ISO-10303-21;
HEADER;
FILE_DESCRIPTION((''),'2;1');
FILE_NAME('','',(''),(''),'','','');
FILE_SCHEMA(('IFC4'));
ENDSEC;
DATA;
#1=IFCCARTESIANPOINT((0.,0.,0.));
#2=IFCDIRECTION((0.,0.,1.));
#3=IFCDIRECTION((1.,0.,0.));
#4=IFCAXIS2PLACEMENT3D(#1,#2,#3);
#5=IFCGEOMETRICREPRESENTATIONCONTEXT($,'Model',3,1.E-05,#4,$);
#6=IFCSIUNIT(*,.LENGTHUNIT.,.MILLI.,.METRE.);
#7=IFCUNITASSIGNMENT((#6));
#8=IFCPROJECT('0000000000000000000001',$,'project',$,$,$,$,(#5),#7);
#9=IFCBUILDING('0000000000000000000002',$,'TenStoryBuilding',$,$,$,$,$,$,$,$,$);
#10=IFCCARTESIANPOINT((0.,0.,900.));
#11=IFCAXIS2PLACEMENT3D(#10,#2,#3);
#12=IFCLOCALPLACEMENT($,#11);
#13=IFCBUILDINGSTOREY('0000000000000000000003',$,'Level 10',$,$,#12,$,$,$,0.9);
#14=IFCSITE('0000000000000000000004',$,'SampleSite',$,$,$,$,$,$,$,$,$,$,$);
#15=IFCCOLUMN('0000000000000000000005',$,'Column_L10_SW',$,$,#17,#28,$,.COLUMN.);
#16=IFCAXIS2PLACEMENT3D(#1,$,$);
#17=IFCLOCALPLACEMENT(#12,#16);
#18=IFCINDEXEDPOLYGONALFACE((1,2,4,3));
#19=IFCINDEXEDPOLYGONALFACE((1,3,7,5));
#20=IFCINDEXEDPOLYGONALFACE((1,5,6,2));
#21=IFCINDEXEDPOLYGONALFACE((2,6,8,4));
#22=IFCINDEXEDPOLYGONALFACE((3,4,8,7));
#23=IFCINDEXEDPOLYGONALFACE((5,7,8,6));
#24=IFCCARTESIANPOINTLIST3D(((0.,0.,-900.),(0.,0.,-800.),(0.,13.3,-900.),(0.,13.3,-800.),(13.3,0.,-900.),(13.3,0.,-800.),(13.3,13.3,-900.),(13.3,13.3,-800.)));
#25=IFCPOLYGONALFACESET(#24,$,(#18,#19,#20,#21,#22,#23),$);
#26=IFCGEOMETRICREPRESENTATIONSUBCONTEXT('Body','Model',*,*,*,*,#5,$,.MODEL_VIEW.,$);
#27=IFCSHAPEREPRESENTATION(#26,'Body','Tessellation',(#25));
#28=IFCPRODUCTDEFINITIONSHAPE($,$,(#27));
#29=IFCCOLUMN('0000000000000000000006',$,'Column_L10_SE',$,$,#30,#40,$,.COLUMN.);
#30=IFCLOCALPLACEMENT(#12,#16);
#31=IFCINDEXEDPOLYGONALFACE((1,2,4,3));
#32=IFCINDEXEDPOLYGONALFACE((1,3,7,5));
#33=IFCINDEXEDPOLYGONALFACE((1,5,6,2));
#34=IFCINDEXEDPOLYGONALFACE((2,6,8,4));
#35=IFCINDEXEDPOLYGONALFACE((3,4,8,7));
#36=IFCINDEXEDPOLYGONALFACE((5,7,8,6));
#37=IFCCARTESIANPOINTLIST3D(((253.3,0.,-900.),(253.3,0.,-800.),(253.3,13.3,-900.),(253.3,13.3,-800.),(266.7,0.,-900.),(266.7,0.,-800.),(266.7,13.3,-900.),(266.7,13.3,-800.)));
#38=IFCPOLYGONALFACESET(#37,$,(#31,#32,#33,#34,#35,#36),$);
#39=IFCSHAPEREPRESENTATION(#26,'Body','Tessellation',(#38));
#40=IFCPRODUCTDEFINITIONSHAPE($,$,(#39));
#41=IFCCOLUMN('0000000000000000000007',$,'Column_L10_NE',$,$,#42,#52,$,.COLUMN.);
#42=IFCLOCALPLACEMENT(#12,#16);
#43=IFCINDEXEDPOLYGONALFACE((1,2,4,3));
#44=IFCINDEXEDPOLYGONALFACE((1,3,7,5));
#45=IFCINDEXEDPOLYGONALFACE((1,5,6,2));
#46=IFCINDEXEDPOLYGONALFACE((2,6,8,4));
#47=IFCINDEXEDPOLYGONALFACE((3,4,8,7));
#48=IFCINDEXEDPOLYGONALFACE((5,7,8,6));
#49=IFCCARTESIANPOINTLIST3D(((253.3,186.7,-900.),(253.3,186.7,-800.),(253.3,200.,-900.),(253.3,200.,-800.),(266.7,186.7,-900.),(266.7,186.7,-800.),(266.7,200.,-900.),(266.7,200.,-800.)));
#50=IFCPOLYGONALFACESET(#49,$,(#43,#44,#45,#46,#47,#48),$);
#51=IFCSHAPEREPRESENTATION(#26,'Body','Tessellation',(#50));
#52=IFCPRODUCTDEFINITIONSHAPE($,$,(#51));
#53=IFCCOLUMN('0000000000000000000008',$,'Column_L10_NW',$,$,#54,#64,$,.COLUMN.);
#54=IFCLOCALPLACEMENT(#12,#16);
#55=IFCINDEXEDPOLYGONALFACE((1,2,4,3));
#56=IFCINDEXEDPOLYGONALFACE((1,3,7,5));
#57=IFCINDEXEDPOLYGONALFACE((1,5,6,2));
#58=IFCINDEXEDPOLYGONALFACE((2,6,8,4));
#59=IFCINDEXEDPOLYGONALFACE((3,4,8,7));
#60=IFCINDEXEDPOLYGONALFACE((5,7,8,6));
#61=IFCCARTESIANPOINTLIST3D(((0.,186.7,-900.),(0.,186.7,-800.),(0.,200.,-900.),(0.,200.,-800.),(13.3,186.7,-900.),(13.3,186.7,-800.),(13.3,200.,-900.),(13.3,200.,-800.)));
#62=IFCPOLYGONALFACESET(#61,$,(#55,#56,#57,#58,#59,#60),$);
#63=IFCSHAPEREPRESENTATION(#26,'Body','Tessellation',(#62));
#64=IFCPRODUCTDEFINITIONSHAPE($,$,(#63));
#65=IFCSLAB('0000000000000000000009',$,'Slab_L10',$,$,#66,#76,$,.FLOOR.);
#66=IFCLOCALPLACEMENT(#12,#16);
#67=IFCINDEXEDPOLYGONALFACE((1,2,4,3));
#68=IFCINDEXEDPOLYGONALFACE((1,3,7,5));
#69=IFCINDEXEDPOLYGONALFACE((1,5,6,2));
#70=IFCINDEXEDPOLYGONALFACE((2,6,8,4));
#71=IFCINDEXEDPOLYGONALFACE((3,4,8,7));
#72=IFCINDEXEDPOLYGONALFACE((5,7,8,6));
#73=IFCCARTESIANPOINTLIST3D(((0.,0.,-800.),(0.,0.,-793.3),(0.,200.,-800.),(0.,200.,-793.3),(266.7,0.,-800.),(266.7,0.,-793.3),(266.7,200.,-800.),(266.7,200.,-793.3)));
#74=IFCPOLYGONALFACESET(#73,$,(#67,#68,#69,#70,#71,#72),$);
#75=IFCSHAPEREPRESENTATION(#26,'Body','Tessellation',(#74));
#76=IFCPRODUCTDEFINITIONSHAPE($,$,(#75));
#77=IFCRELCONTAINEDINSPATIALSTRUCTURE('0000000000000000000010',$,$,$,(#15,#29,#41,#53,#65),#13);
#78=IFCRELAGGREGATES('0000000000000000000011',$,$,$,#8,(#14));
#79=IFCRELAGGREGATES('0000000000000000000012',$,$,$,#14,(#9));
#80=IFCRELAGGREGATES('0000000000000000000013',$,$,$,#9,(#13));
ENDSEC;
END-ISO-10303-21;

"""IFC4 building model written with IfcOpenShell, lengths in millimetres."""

from ifc_helpers import new_model, si_unit, frame, origin_with_axes, origin_2d, place, context, subcontext, project, spatial, indexed_curve, rectangle, outline, extrude, element, save


model = new_model("IFC4")

# Units and contexts
model_context = context("Model", 3, precision=1e-05, world=origin_with_axes())
body_context = subcontext(model_context, "Body", "Model", "MODEL_VIEW")
ifc_project = project(units=[si_unit("LENGTHUNIT", "METRE", prefix="MILLI")], contexts=[model_context])

# Site, building, storey
site = spatial("IfcSite", under=ifc_project, Name="SampleSite")
building = spatial("IfcBuilding", under=site, Name="TenStoryBuilding")
storey_placement = place(None, frame((0.0, 0.0, 900.0), z_axis=(0.0, 0.0, 1.0), x_axis=(1.0, 0.0, 0.0)))
storey = spatial("IfcBuildingStorey", under=building, at=storey_placement, Name="Level 10", Elevation=0.9)

# Columns
for number, where, z_axis, x_axis, name in (
    (1, (6.7, 6.7, -900.0), (0.0, 0.0, 1.0), (1.0, 0.0, 0.0), "Column_L10_SW"),
    (2, (260.0, 6.7, -900.0), (0.0, 0.0, 1.0), (1.0, 0.0, 0.0), "Column_L10_SE"),
    (3, (260.0, 193.3, -900.0), (0.0, 0.0, 1.0), (1.0, 0.0, 0.0), "Column_L10_NE"),
    (4, (6.7, 193.3, -900.0), (0.0, 0.0, 1.0), (1.0, 0.0, 0.0), "Column_L10_NW"),
):
    element("IfcColumn", number, at=place(storey_placement, frame(where, z_axis=z_axis, x_axis=x_axis)), inside=storey, Name=name, PredefinedType="COLUMN", context=body_context, shape_type="SweptSolid", body=[
        extrude(rectangle(XDim=13.3, YDim=13.3, at=origin_2d()), origin_with_axes(), (0.0, 0.0, 1.0), 100.0),
    ])

# Slab
slab_placement = place(storey_placement, frame((0.0, 0.0, -800.0), z_axis=(0.0, 0.0, 1.0), x_axis=(1.0, 0.0, 0.0)))
element("IfcSlab", 5, at=slab_placement, inside=storey, Name="Slab_L10", PredefinedType="FLOOR", context=body_context, shape_type="SweptSolid", body=[
    extrude(outline(indexed_curve([(0.0, 0.0), (266.7, 0.0), (266.7, 200.0), (0.0, 200.0), (0.0, 0.0)])), None, (0.0, 0.0, 1.0), 6.7),
])

save(model, "model.ifc")
